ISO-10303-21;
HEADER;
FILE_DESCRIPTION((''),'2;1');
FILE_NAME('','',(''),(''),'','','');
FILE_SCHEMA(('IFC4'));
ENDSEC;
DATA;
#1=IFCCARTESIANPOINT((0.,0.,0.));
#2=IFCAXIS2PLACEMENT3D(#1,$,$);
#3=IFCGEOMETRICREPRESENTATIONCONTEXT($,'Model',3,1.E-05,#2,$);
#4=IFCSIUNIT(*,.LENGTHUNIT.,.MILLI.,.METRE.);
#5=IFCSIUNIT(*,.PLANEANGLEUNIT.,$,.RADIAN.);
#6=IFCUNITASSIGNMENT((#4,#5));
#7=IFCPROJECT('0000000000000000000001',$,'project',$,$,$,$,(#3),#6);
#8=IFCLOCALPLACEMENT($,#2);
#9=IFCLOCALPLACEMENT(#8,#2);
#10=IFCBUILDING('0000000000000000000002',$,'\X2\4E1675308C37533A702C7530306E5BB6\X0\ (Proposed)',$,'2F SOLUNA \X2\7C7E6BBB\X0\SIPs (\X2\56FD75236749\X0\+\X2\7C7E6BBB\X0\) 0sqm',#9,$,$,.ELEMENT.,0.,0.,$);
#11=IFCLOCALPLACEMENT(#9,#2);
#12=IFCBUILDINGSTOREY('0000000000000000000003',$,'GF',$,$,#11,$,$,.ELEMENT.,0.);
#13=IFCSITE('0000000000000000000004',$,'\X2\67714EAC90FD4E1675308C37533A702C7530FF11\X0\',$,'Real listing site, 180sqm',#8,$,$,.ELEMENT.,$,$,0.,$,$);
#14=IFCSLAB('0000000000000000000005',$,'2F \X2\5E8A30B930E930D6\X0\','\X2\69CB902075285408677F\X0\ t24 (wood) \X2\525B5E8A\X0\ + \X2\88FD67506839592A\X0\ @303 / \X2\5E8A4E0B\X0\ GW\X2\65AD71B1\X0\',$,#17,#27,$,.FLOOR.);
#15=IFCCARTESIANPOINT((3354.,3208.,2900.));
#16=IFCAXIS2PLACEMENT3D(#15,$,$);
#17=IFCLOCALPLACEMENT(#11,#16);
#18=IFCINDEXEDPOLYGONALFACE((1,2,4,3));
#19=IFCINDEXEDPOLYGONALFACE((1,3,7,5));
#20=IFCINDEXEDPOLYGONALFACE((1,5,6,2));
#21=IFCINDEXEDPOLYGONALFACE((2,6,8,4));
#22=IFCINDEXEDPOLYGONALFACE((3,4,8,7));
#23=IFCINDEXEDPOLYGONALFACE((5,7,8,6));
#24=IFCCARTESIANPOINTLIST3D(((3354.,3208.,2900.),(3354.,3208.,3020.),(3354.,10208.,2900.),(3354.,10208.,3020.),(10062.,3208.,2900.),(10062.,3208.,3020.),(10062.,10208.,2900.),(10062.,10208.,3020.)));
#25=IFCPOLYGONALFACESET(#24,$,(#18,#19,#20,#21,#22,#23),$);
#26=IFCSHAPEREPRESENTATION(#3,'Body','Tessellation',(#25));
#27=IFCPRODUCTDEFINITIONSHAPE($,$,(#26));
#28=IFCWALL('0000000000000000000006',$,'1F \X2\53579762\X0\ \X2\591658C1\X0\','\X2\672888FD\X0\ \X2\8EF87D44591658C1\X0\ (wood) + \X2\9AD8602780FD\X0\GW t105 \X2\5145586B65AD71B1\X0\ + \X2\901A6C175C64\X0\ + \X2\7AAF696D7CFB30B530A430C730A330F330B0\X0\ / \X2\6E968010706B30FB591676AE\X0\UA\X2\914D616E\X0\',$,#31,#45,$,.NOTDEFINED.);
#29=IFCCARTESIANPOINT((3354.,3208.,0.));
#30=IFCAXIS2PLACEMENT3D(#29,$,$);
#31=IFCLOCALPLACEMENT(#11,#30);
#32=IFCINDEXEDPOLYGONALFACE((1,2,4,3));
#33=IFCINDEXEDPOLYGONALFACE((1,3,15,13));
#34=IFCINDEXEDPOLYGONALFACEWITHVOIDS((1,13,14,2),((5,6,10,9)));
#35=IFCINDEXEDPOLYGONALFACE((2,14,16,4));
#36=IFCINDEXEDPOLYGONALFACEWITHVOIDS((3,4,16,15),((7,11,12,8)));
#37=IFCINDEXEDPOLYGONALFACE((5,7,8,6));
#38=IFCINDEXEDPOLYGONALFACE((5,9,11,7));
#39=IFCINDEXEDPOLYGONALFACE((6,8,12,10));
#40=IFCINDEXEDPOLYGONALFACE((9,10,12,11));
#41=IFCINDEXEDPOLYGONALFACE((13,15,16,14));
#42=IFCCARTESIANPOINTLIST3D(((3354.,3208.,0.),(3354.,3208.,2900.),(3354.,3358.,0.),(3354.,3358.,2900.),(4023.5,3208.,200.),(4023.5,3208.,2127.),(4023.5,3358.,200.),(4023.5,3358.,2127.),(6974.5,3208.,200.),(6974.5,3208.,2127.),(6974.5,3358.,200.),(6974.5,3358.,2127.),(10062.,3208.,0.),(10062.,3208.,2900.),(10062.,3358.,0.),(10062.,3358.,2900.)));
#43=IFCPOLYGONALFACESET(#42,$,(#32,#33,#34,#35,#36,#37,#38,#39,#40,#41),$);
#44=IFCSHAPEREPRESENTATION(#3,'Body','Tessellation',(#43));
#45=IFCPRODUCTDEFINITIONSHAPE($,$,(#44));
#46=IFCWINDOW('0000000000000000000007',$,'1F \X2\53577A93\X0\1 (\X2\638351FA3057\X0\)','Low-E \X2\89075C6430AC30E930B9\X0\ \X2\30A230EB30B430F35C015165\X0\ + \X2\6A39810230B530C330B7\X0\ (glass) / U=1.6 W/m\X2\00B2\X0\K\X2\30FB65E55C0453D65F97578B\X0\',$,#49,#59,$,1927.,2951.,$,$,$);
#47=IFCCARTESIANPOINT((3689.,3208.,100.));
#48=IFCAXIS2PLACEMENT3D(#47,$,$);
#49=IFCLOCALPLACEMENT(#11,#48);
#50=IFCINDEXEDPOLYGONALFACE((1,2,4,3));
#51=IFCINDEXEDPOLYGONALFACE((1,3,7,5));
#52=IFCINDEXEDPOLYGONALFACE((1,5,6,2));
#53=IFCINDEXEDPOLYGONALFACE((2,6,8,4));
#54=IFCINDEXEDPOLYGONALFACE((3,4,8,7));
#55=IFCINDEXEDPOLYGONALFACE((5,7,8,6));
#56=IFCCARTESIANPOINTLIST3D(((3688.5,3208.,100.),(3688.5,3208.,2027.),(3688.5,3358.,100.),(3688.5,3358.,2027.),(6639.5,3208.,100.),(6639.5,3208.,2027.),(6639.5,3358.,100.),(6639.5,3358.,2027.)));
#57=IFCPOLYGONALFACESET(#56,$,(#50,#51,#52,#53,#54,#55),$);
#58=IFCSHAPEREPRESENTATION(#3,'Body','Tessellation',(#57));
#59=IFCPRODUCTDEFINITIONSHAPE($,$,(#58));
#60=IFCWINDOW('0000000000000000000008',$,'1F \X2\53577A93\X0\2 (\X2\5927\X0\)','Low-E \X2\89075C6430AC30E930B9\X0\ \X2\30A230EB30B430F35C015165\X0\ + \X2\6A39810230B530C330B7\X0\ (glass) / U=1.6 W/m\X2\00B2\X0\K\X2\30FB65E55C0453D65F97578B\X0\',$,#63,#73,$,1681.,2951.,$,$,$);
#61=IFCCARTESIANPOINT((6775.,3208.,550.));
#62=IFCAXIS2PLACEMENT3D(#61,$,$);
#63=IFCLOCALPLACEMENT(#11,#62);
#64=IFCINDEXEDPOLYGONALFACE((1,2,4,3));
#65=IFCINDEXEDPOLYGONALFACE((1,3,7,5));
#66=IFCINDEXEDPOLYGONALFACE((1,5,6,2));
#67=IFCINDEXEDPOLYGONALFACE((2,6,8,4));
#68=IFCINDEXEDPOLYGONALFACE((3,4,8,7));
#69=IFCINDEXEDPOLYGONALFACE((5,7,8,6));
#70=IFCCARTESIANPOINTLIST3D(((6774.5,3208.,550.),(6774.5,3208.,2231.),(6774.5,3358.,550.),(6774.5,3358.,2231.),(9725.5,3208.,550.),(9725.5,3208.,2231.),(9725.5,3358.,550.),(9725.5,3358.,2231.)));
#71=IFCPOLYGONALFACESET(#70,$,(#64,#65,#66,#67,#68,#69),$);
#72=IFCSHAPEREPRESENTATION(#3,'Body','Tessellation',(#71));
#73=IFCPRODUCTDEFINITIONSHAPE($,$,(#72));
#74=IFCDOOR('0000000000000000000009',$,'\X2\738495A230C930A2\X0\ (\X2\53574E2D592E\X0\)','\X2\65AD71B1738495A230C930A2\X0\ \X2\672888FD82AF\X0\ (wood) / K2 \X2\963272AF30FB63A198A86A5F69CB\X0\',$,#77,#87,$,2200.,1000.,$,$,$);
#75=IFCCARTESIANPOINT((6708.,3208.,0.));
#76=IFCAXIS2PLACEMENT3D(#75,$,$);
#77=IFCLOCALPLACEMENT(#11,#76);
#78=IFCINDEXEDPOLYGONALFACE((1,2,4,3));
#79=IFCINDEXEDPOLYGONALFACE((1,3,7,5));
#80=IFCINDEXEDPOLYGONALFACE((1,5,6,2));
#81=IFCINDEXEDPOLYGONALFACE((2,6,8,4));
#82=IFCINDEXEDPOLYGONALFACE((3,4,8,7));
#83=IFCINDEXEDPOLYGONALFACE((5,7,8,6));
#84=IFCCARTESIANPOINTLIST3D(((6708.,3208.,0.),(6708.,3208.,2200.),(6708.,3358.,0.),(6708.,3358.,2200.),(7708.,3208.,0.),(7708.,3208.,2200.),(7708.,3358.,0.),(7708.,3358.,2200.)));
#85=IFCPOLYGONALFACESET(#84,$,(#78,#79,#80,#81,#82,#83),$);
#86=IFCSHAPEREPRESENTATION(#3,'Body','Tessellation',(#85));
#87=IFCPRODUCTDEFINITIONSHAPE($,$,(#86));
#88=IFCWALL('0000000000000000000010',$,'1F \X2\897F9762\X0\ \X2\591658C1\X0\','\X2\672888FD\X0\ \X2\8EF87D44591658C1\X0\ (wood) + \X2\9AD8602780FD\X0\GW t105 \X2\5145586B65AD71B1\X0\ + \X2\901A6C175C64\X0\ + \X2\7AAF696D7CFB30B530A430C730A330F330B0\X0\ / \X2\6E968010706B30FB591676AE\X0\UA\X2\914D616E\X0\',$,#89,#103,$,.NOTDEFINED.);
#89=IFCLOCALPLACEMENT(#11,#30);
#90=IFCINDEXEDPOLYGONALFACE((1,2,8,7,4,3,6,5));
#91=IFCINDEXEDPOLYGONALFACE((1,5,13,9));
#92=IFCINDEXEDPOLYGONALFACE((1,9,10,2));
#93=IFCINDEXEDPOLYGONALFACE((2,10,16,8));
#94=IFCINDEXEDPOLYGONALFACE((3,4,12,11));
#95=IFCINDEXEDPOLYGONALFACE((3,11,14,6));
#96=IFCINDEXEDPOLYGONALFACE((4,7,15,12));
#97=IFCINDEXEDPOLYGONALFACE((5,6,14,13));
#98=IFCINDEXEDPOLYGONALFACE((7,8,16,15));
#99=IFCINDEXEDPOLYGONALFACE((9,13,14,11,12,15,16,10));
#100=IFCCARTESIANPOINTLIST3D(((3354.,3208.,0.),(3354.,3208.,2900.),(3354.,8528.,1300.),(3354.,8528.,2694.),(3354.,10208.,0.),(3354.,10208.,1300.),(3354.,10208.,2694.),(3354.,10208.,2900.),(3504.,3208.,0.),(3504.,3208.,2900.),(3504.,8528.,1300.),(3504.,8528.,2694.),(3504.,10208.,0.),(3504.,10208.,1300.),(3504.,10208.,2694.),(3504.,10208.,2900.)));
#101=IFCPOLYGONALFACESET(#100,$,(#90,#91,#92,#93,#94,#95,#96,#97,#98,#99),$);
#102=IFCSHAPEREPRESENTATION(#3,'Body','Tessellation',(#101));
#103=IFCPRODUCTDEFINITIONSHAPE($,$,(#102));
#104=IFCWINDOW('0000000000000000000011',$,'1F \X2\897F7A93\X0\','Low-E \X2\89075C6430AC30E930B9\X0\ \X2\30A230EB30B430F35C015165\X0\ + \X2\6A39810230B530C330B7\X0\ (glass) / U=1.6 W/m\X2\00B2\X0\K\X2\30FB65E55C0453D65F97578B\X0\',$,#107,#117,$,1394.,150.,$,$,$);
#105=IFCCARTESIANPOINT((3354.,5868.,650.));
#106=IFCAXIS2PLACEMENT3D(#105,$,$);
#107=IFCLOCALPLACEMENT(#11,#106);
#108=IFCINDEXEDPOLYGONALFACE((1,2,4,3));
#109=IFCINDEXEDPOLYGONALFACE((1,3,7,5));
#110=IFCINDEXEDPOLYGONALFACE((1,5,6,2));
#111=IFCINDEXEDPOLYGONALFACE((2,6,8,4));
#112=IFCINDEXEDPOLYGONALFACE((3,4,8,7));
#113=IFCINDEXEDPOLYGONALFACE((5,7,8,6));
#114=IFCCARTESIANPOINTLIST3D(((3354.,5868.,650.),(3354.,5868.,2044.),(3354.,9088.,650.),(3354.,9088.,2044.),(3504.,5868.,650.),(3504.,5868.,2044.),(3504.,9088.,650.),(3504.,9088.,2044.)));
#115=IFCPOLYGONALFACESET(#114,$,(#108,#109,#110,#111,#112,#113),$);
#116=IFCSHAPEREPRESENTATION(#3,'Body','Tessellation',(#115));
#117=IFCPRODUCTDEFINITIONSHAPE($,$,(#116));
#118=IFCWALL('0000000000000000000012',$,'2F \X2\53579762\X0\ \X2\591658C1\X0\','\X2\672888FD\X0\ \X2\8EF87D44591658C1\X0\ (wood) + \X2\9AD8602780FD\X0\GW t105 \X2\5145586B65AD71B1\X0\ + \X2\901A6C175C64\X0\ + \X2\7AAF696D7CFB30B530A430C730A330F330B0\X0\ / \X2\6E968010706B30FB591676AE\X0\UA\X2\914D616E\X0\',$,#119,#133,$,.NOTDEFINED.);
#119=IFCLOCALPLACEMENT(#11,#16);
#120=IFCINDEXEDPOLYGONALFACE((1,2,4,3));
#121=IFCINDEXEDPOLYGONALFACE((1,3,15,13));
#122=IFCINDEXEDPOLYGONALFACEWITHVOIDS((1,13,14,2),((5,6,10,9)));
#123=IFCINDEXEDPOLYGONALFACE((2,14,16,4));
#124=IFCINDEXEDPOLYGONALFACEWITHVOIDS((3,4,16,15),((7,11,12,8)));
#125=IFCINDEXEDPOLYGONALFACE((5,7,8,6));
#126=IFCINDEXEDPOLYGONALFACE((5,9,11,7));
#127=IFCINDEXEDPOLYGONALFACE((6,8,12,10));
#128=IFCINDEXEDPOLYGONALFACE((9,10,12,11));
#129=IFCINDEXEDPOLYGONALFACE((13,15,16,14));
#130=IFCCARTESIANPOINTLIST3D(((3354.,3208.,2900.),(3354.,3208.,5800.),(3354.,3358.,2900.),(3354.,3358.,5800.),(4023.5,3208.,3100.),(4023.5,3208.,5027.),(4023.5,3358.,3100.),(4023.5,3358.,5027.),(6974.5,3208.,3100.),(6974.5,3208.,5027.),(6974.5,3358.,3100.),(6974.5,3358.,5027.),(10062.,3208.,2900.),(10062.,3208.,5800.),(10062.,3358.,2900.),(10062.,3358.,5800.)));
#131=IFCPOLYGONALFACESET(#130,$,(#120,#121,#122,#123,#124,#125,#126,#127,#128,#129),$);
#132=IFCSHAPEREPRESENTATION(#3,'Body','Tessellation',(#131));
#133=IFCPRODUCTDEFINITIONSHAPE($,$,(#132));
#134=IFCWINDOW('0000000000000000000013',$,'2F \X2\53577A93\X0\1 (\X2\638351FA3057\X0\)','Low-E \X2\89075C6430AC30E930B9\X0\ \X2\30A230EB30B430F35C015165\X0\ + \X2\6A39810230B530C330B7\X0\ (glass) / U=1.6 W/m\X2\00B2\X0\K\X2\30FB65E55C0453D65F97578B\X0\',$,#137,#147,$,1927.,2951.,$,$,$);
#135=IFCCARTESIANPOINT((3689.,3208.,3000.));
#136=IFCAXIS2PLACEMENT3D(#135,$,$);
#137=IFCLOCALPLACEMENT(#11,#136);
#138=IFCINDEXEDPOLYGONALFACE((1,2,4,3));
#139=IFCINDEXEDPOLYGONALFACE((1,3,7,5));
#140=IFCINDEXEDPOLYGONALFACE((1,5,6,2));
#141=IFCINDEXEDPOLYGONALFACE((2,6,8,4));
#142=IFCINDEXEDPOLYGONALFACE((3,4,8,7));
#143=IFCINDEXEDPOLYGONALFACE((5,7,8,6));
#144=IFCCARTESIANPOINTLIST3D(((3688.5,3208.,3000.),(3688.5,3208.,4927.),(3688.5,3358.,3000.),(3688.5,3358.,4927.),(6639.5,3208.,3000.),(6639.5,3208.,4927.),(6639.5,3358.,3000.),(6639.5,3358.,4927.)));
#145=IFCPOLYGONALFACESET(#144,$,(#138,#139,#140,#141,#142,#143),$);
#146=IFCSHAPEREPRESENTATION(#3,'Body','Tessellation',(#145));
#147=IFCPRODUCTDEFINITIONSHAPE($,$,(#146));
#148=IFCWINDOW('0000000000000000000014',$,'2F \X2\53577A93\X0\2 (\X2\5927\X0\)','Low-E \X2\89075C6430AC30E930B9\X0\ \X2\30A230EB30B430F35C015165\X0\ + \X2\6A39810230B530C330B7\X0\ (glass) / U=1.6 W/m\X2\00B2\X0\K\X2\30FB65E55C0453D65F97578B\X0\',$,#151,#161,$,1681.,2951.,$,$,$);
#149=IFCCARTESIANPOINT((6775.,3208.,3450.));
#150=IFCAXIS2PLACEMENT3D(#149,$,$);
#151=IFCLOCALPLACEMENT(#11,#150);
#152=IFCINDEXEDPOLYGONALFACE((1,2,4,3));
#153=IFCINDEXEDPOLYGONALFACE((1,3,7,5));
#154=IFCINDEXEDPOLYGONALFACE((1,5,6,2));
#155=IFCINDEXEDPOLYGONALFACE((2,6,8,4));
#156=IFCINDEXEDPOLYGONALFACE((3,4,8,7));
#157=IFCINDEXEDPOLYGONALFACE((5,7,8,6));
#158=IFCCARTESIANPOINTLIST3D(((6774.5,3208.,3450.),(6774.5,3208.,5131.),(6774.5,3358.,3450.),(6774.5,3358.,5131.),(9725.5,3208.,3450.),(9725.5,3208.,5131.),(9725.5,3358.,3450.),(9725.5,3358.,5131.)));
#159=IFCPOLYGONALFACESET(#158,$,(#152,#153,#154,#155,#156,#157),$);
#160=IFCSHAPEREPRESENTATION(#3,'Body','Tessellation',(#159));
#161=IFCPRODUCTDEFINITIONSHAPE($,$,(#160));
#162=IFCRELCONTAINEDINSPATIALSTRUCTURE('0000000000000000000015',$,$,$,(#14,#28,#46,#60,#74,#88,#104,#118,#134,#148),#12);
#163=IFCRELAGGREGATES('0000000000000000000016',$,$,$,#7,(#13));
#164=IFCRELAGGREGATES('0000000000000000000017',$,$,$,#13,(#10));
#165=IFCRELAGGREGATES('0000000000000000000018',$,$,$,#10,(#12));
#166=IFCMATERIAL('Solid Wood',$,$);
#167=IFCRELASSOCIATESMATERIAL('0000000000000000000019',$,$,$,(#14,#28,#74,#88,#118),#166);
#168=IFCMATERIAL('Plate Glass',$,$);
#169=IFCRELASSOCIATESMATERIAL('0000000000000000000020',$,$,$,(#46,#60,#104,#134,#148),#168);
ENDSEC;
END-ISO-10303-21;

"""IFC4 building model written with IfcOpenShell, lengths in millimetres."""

from ifc_helpers import new_model, si_unit, frame, frame_2d, origin, place, context, project, spatial, rectangle, extrude, material, element, fill, save


model = new_model("IFC4")

# Units and contexts
model_context = context("Model", 3, precision=1e-05, world=origin())
ifc_project = project(units=[si_unit("LENGTHUNIT", "METRE", prefix="MILLI"), si_unit("PLANEANGLEUNIT", "RADIAN")], contexts=[model_context])

# Site, building, storey
site_placement = place(None, origin())
site = spatial("IfcSite", under=ifc_project, at=site_placement, Name="東京都世田谷区瀬田１", ObjectType="Real listing site, 180sqm", CompositionType="ELEMENT", RefElevation=0.0)
building_placement = place(site_placement, origin())
building = spatial("IfcBuilding", under=site, at=building_placement, Name="世田谷区瀬田の家 (Proposed)", ObjectType="2F SOLUNA 籾殻SIPs (国産杉+籾殻) 0sqm", CompositionType="ELEMENT", ElevationOfRefHeight=0.0, ElevationOfTerrain=0.0)
storey_placement = place(building_placement, origin())
storey = spatial("IfcBuildingStorey", under=building, at=storey_placement, Name="GF", CompositionType="ELEMENT", Elevation=0.0)

# Slab
ifc_material_1 = material(Name="Solid Wood")
slab_1_placement = place(storey_placement, frame((3354.0, 3208.0, 2900.0)))
element("IfcSlab", 1, at=slab_1_placement, inside=storey, material=ifc_material_1, Name="2F 床スラブ", Description="構造用合板 t24 (wood) 剛床 + 製材根太 @303 / 床下 GW断熱", PredefinedType="FLOOR", context=model_context, shape_type="SweptSolid", body=[
    extrude(rectangle(XDim=6708.0, YDim=7000.0, at=frame_2d((3354.0, 3500.0))), frame((3354.0, 3208.0, 2900.0)), (0.0, 0.0, 1.0), 120.0),
])

# Wall, openings, windows, door
wall_1_placement = place(storey_placement, frame((3354.0, 3208.0, 0.0)))
wall_1 = element("IfcWall", 2, at=wall_1_placement, inside=storey, material=ifc_material_1, Name="1F 南面 外壁", Description="木製 軸組外壁 (wood) + 高性能GW t105 充填断熱 + 通気層 + 窯業系サイディング / 準耐火・外皮UA配慮", PredefinedType="NOTDEFINED", context=model_context, shape_type="SweptSolid", body=[
    extrude(rectangle(XDim=6708.0, YDim=150.0, at=frame_2d((3354.0, 75.0))), frame((3354.0, 3208.0, 0.0)), (0.0, 0.0, 1.0), 2900.0),
])
opening_1_placement = place(storey_placement, frame((3689.0, 3208.0, 100.0)))
opening_1 = element("IfcOpeningElement", 3, at=opening_1_placement, cuts=wall_1, PredefinedType="NOTDEFINED", context=model_context, shape_type="SweptSolid", body=[
    extrude(rectangle(XDim=2951.0, YDim=150.0, at=frame_2d((1475.0, 75.0))), frame((3689.0, 3208.0, 100.0)), (0.0, 0.0, 1.0), 1927.0),
])
opening_2_placement = place(storey_placement, frame((6775.0, 3208.0, 550.0)))
opening_2 = element("IfcOpeningElement", 4, at=opening_2_placement, cuts=wall_1, PredefinedType="NOTDEFINED", context=model_context, shape_type="SweptSolid", body=[
    extrude(rectangle(XDim=2951.0, YDim=150.0, at=frame_2d((1475.0, 75.0))), frame((6775.0, 3208.0, 550.0)), (0.0, 0.0, 1.0), 1681.0),
])
opening_3_placement = place(storey_placement, frame((6708.0, 3208.0, 0.0)))
opening_3 = element("IfcOpeningElement", 5, at=opening_3_placement, cuts=wall_1, PredefinedType="NOTDEFINED", context=model_context, shape_type="SweptSolid", body=[
    extrude(rectangle(XDim=1000.0, YDim=150.0, at=frame_2d((500.0, 75.0))), frame((6708.0, 3208.0, 0.0)), (0.0, 0.0, 1.0), 2200.0),
])
ifc_material_2 = material(Name="Plate Glass")
window_1_placement = place(storey_placement, frame((3689.0, 3208.0, 100.0)))
window_1 = element("IfcWindow", 6, at=window_1_placement, inside=storey, material=ifc_material_2, Name="1F 南窓1 (掃出し)", Description="Low-E 複層ガラス アルゴン封入 + 樹脂サッシ (glass) / U=1.6 W/m²K・日射取得型", OverallHeight=1927.0, OverallWidth=2951.0, context=model_context, shape_type="SweptSolid", body=[
    extrude(rectangle(XDim=2951.0, YDim=150.0, at=frame_2d((1475.0, 75.0))), frame((3689.0, 3208.0, 100.0)), (0.0, 0.0, 1.0), 1927.0),
])
fill(opening_1, window_1)
window_2_placement = place(storey_placement, frame((6775.0, 3208.0, 550.0)))
window_2 = element("IfcWindow", 7, at=window_2_placement, inside=storey, material=ifc_material_2, Name="1F 南窓2 (大)", Description="Low-E 複層ガラス アルゴン封入 + 樹脂サッシ (glass) / U=1.6 W/m²K・日射取得型", OverallHeight=1681.0, OverallWidth=2951.0, context=model_context, shape_type="SweptSolid", body=[
    extrude(rectangle(XDim=2951.0, YDim=150.0, at=frame_2d((1475.0, 75.0))), frame((6775.0, 3208.0, 550.0)), (0.0, 0.0, 1.0), 1681.0),
])
fill(opening_2, window_2)
door_placement = place(storey_placement, frame((6708.0, 3208.0, 0.0)))
door = element("IfcDoor", 8, at=door_placement, inside=storey, material=ifc_material_1, Name="玄関ドア (南中央)", Description="断熱玄関ドア 木製芯 (wood) / K2 防犯・採風機構", OverallHeight=2200.0, OverallWidth=1000.0, context=model_context, shape_type="SweptSolid", body=[
    extrude(rectangle(XDim=1000.0, YDim=150.0, at=frame_2d((500.0, 75.0))), frame((6708.0, 3208.0, 0.0)), (0.0, 0.0, 1.0), 2200.0),
])
fill(opening_3, door)

# Wall, opening, window
wall_2_placement = place(storey_placement, frame((3354.0, 3208.0, 0.0)))
wall_2 = element("IfcWall", 9, at=wall_2_placement, inside=storey, material=ifc_material_1, Name="1F 西面 外壁", Description="木製 軸組外壁 (wood) + 高性能GW t105 充填断熱 + 通気層 + 窯業系サイディング / 準耐火・外皮UA配慮", PredefinedType="NOTDEFINED", context=model_context, shape_type="SweptSolid", body=[
    extrude(rectangle(XDim=150.0, YDim=7000.0, at=frame_2d((75.0, 3500.0))), frame((3354.0, 3208.0, 0.0)), (0.0, 0.0, 1.0), 2900.0),
])
opening_4_placement = place(storey_placement, frame((3354.0, 5868.0, 650.0)))
opening_4 = element("IfcOpeningElement", 10, at=opening_4_placement, cuts=wall_2, PredefinedType="NOTDEFINED", context=model_context, shape_type="SweptSolid", body=[
    extrude(rectangle(XDim=150.0, YDim=3220.0, at=frame_2d((75.0, 1610.0))), frame((3354.0, 5868.0, 650.0)), (0.0, 0.0, 1.0), 1394.0),
])
window_3_placement = place(storey_placement, frame((3354.0, 5868.0, 650.0)))
window_3 = element("IfcWindow", 11, at=window_3_placement, inside=storey, material=ifc_material_2, Name="1F 西窓", Description="Low-E 複層ガラス アルゴン封入 + 樹脂サッシ (glass) / U=1.6 W/m²K・日射取得型", OverallHeight=1394.0, OverallWidth=150.0, context=model_context, shape_type="SweptSolid", body=[
    extrude(rectangle(XDim=150.0, YDim=3220.0, at=frame_2d((75.0, 1610.0))), frame((3354.0, 5868.0, 650.0)), (0.0, 0.0, 1.0), 1394.0),
])
fill(opening_4, window_3)

# Wall, openings, windows
wall_3_placement = place(storey_placement, frame((3354.0, 3208.0, 2900.0)))
wall_3 = element("IfcWall", 12, at=wall_3_placement, inside=storey, material=ifc_material_1, Name="2F 南面 外壁", Description="木製 軸組外壁 (wood) + 高性能GW t105 充填断熱 + 通気層 + 窯業系サイディング / 準耐火・外皮UA配慮", PredefinedType="NOTDEFINED", context=model_context, shape_type="SweptSolid", body=[
    extrude(rectangle(XDim=6708.0, YDim=150.0, at=frame_2d((3354.0, 75.0))), frame((3354.0, 3208.0, 2900.0)), (0.0, 0.0, 1.0), 2900.0),
])
opening_5_placement = place(storey_placement, frame((3689.0, 3208.0, 3000.0)))
opening_5 = element("IfcOpeningElement", 13, at=opening_5_placement, cuts=wall_3, PredefinedType="NOTDEFINED", context=model_context, shape_type="SweptSolid", body=[
    extrude(rectangle(XDim=2951.0, YDim=150.0, at=frame_2d((1475.0, 75.0))), frame((3689.0, 3208.0, 3000.0)), (0.0, 0.0, 1.0), 1927.0),
])
opening_6_placement = place(storey_placement, frame((6775.0, 3208.0, 3450.0)))
opening_6 = element("IfcOpeningElement", 14, at=opening_6_placement, cuts=wall_3, PredefinedType="NOTDEFINED", context=model_context, shape_type="SweptSolid", body=[
    extrude(rectangle(XDim=2951.0, YDim=150.0, at=frame_2d((1475.0, 75.0))), frame((6775.0, 3208.0, 3450.0)), (0.0, 0.0, 1.0), 1681.0),
])
window_4_placement = place(storey_placement, frame((3689.0, 3208.0, 3000.0)))
window_4 = element("IfcWindow", 15, at=window_4_placement, inside=storey, material=ifc_material_2, Name="2F 南窓1 (掃出し)", Description="Low-E 複層ガラス アルゴン封入 + 樹脂サッシ (glass) / U=1.6 W/m²K・日射取得型", OverallHeight=1927.0, OverallWidth=2951.0, context=model_context, shape_type="SweptSolid", body=[
    extrude(rectangle(XDim=2951.0, YDim=150.0, at=frame_2d((1475.0, 75.0))), frame((3689.0, 3208.0, 3000.0)), (0.0, 0.0, 1.0), 1927.0),
])
fill(opening_5, window_4)
window_5_placement = place(storey_placement, frame((6775.0, 3208.0, 3450.0)))
window_5 = element("IfcWindow", 16, at=window_5_placement, inside=storey, material=ifc_material_2, Name="2F 南窓2 (大)", Description="Low-E 複層ガラス アルゴン封入 + 樹脂サッシ (glass) / U=1.6 W/m²K・日射取得型", OverallHeight=1681.0, OverallWidth=2951.0, context=model_context, shape_type="SweptSolid", body=[
    extrude(rectangle(XDim=2951.0, YDim=150.0, at=frame_2d((1475.0, 75.0))), frame((6775.0, 3208.0, 3450.0)), (0.0, 0.0, 1.0), 1681.0),
])
fill(opening_6, window_5)

save(model, "model.ifc")
